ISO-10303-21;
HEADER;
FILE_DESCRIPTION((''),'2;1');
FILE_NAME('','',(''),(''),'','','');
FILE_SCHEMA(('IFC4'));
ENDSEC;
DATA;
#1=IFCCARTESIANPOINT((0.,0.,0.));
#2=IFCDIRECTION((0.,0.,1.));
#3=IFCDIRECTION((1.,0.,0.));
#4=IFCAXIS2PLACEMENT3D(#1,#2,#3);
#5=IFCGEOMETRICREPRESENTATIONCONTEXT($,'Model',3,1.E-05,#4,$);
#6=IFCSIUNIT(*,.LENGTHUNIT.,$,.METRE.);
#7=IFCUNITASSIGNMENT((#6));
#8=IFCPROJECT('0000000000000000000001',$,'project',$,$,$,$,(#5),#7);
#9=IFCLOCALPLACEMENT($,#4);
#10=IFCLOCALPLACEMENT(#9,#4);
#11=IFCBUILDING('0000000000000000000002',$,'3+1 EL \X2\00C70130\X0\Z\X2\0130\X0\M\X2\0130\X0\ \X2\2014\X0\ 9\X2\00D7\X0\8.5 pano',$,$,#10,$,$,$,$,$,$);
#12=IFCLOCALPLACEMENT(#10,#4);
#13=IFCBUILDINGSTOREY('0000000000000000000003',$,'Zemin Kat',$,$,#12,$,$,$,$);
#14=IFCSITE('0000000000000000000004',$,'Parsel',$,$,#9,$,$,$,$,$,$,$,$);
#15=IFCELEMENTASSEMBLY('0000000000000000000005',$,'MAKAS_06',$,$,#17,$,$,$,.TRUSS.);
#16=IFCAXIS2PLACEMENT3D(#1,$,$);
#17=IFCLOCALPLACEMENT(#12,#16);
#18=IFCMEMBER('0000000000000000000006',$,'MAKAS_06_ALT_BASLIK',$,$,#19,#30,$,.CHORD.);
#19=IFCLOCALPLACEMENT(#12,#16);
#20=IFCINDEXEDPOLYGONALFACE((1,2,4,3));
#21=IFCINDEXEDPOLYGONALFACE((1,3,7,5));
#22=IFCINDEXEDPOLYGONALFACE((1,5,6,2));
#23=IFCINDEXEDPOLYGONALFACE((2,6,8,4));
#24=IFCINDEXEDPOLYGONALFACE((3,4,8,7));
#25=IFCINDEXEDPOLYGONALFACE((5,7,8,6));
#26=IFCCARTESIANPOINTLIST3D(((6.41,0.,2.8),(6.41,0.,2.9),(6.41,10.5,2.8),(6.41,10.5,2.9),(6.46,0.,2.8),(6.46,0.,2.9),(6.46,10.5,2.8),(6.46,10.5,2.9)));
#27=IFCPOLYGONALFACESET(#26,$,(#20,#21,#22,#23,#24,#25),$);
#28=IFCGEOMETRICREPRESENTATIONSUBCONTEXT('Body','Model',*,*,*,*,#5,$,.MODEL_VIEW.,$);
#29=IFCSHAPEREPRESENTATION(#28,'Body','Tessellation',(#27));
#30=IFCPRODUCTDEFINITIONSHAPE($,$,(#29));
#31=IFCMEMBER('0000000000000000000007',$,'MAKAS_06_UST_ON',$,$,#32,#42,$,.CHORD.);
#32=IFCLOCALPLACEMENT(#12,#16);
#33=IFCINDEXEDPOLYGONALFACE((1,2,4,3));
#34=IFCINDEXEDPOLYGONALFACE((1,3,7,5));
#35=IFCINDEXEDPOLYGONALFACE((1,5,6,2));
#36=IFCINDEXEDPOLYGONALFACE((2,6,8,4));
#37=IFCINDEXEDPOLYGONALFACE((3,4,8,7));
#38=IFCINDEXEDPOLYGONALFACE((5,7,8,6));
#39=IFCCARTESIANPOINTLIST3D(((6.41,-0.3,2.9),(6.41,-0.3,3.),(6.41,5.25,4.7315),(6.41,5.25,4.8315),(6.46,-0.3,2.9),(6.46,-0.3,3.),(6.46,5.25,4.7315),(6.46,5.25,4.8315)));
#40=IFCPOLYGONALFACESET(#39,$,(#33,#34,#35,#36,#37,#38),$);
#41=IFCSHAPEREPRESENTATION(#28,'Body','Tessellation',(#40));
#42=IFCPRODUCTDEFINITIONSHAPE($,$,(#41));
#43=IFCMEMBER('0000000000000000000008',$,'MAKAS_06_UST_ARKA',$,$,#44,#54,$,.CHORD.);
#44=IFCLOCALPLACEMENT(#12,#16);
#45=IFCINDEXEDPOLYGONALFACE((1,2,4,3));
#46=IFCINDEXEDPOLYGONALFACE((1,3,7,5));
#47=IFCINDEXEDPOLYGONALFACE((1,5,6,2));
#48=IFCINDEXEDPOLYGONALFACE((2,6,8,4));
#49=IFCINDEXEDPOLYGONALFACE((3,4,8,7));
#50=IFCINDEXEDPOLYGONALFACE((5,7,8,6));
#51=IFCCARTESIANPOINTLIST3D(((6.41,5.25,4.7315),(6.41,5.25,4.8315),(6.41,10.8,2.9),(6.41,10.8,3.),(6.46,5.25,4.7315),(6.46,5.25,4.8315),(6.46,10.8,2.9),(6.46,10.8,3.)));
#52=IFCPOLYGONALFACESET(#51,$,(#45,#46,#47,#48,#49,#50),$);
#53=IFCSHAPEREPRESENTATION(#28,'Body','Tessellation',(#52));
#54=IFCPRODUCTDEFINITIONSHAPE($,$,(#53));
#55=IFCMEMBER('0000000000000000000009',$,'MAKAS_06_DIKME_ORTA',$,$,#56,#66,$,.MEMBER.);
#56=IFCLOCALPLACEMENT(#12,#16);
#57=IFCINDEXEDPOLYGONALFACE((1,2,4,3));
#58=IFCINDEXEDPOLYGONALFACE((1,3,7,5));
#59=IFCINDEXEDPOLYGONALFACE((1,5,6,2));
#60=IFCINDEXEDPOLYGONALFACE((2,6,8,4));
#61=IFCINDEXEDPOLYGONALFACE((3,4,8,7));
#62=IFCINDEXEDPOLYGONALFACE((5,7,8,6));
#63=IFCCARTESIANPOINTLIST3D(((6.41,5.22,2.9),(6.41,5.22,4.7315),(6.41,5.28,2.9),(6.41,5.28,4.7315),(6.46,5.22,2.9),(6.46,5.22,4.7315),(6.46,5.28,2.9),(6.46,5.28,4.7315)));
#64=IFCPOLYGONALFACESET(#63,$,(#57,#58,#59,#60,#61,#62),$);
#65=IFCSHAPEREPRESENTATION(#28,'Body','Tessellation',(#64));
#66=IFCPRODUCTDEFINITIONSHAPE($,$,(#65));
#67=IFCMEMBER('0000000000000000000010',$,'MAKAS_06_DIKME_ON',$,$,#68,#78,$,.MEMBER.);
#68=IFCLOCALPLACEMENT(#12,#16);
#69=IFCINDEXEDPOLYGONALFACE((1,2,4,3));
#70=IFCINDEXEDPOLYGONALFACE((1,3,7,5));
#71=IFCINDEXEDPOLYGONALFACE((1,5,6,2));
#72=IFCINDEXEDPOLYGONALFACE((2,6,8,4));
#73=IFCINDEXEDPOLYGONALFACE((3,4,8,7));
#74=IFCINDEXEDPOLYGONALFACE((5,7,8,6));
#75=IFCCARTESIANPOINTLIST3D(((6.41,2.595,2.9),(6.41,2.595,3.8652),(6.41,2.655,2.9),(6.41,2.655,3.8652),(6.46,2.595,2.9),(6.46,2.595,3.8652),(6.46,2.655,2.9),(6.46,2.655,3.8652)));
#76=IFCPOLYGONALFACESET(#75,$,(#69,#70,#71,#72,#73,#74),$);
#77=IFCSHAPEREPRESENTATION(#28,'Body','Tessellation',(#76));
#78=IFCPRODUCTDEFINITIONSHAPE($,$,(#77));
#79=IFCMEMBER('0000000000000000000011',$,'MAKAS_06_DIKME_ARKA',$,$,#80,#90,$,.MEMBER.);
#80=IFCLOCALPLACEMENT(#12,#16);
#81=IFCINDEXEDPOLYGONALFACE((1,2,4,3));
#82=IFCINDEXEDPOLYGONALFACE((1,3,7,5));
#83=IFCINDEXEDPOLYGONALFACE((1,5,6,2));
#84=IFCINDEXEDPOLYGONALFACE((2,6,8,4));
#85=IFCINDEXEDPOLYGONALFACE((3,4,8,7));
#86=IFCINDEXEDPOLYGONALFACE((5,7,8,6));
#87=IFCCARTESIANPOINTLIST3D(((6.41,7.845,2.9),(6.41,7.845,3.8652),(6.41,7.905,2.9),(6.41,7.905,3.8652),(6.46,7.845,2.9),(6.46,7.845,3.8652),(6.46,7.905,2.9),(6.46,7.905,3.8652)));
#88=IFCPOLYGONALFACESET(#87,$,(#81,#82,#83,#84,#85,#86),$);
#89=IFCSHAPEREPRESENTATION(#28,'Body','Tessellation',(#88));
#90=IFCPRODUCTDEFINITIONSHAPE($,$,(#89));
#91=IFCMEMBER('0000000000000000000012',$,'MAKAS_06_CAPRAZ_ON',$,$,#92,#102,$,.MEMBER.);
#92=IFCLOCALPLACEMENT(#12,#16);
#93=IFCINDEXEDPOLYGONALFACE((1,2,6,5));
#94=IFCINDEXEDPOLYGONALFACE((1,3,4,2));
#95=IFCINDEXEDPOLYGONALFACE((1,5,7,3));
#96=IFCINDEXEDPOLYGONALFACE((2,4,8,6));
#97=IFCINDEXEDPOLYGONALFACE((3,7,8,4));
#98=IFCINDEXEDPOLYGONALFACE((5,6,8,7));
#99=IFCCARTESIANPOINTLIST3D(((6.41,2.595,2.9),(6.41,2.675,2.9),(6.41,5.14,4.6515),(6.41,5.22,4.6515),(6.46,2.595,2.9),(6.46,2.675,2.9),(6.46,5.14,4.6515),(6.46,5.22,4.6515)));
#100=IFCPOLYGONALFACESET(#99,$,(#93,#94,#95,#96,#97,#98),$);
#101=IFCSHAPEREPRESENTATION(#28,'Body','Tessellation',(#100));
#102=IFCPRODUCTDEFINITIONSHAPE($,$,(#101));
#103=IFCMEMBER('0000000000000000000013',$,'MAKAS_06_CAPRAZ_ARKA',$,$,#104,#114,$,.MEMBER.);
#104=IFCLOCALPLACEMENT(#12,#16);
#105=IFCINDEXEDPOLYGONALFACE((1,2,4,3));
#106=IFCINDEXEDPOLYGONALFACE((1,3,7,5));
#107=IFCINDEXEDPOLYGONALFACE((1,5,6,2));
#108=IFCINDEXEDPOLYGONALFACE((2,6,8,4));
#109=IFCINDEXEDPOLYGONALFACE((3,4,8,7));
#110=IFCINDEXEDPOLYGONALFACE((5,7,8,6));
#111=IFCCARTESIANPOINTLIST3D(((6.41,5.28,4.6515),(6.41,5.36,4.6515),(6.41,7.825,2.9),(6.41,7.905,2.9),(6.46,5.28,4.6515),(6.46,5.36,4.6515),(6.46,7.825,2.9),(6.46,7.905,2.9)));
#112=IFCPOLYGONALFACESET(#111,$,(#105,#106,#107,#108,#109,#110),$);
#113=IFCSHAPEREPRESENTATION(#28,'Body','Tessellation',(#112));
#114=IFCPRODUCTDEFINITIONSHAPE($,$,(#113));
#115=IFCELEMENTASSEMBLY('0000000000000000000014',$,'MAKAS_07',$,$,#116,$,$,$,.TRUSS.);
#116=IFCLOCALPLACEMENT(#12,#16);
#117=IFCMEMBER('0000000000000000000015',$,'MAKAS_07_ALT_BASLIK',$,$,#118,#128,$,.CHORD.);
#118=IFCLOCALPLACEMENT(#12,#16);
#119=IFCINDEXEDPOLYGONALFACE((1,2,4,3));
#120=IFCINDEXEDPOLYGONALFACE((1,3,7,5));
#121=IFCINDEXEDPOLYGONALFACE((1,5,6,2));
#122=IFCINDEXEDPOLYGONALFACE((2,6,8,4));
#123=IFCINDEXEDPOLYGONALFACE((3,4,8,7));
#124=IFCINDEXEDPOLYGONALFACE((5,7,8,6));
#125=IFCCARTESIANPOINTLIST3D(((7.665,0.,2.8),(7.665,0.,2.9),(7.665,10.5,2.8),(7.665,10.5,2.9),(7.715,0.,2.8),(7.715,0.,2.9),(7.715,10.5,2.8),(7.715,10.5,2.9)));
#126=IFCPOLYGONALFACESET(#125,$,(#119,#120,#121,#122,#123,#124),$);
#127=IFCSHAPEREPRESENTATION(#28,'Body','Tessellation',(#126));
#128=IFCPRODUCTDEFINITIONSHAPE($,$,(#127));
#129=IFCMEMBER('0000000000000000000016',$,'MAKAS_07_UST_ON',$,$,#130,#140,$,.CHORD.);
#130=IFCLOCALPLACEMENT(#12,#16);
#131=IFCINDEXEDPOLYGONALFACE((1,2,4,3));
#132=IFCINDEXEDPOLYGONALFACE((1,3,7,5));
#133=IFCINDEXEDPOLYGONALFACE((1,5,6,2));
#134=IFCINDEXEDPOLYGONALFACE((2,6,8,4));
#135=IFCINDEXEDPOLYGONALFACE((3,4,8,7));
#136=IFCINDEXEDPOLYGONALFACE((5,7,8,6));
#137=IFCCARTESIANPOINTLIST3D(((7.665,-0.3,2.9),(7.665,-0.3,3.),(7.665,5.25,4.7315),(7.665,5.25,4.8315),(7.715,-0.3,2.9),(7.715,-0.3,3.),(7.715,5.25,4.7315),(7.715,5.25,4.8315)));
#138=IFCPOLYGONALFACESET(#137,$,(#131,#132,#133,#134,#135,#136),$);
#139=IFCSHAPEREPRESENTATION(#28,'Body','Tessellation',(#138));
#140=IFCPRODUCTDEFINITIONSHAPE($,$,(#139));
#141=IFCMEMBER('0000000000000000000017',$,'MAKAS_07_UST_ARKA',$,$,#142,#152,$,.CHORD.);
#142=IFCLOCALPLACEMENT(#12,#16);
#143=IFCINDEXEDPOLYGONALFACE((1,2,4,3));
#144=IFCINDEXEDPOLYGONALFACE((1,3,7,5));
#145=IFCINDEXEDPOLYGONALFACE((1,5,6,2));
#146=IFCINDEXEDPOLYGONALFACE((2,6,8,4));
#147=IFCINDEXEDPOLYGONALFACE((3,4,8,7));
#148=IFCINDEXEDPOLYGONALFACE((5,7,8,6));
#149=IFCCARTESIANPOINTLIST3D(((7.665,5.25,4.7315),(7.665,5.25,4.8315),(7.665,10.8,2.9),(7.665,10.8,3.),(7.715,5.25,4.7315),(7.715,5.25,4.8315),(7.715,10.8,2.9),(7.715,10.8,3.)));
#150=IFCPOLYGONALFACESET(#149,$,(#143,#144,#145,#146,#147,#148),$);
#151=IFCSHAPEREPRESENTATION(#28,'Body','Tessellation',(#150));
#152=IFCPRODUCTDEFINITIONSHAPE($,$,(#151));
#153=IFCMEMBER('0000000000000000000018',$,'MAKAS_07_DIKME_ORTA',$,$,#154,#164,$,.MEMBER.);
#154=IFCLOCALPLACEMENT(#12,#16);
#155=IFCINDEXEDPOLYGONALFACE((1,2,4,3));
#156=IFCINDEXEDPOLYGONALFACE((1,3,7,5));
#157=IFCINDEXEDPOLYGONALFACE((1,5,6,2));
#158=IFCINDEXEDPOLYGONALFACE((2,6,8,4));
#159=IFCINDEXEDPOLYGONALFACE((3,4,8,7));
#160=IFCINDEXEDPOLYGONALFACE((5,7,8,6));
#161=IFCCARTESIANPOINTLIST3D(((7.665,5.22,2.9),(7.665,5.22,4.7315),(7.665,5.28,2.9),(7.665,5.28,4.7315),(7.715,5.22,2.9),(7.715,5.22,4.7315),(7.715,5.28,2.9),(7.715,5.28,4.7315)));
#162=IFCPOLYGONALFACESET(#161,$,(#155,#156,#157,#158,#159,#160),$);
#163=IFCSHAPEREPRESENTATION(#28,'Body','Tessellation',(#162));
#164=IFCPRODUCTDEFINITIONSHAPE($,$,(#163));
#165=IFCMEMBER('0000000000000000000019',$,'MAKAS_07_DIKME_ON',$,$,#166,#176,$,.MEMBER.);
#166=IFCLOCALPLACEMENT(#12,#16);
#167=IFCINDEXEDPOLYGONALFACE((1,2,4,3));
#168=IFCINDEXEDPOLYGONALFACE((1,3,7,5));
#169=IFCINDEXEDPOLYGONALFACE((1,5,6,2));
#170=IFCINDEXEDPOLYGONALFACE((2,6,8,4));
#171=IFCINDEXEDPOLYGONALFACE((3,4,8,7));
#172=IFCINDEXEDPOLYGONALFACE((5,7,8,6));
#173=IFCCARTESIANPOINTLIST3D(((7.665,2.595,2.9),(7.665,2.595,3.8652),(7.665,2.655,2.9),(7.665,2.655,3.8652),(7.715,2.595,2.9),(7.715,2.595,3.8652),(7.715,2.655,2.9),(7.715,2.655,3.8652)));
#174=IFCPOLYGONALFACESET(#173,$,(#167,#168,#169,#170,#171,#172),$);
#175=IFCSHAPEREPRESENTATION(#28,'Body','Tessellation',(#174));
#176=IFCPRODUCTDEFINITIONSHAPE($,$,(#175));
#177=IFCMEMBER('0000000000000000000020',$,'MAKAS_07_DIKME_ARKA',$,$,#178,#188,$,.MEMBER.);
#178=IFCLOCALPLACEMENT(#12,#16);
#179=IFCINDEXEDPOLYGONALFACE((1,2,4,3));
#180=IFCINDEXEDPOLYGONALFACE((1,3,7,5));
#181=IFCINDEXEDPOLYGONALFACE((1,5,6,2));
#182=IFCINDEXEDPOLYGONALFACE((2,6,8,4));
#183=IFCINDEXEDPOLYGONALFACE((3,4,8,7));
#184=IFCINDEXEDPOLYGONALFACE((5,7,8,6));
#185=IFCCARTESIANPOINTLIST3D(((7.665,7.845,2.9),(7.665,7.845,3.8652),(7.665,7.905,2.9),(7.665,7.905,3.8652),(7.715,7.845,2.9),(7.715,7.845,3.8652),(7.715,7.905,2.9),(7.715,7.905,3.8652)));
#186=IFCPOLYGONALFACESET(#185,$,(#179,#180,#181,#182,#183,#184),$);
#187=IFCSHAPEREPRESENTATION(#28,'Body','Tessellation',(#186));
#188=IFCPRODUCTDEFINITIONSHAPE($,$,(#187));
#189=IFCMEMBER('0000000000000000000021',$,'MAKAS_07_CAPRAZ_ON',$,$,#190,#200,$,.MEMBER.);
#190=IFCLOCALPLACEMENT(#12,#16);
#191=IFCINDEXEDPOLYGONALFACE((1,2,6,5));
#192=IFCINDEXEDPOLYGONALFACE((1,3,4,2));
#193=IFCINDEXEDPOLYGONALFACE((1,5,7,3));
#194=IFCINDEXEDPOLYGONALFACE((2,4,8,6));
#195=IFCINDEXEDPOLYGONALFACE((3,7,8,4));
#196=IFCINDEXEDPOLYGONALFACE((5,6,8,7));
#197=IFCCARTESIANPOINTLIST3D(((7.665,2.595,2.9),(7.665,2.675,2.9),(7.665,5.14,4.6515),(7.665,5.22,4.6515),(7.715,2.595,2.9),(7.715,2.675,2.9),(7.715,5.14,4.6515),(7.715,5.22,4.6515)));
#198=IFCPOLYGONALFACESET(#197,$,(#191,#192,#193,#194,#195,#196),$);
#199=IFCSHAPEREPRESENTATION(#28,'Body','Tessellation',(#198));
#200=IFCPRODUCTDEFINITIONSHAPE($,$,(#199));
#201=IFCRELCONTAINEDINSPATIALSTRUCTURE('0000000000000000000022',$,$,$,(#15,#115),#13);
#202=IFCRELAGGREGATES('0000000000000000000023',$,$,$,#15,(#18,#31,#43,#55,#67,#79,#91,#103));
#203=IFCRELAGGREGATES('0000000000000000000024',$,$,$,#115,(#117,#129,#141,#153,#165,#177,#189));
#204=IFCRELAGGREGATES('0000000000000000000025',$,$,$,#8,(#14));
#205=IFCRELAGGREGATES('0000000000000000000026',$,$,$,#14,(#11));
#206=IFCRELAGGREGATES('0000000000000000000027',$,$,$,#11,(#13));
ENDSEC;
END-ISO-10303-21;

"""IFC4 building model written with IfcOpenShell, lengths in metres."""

from ifc_helpers import new_model, si_unit, frame, origin_with_axes, place, context, subcontext, project, spatial, line, indexed_curve, outline, extrude, element, aggregate, save


model = new_model("IFC4")

# Units and contexts
model_context = context("Model", 3, precision=1e-05, world=origin_with_axes())
body_context = subcontext(model_context, "Body", "Model", "MODEL_VIEW")
ifc_project = project(units=[si_unit("LENGTHUNIT", "METRE")], contexts=[model_context])

# Site, building, storey
site_placement = place(None, origin_with_axes())
site = spatial("IfcSite", under=ifc_project, at=site_placement, Name="Parsel")
building_placement = place(site_placement, origin_with_axes())
building = spatial("IfcBuilding", under=site, at=building_placement, Name="3+1 EL ÇİZİMİ — 9×8.5 pano")
storey_placement = place(building_placement, origin_with_axes())
storey = spatial("IfcBuildingStorey", under=building, at=storey_placement, Name="Zemin Kat")

# Element assemblies, members
assembly_1_placement = place(storey_placement, origin_with_axes())
assembly_1 = element("IfcElementAssembly", 1, at=assembly_1_placement, inside=storey, Name="MAKAS_06", PredefinedType="TRUSS")
member_1_placement = place(assembly_1_placement, origin_with_axes())
member_1 = element("IfcMember", 2, at=member_1_placement, Name="MAKAS_06_ALT_BASLIK", PredefinedType="CHORD", context=body_context, shape_type="SweptSolid", body=[
    extrude(outline(indexed_curve([(0.0, 2.8), (10.5, 2.8), (10.5, 2.9), (0.0, 2.9)], segments=[line(1, 2, 3, 4, 1)])), frame((6.41, 0.0, 0.0), z_axis=(1.0, 0.0, 0.0), x_axis=(0.0, 1.0, 0.0)), (0.0, 0.0, 1.0), 0.05),
])
member_2_placement = place(assembly_1_placement, origin_with_axes())
member_2 = element("IfcMember", 3, at=member_2_placement, Name="MAKAS_06_UST_ON", PredefinedType="CHORD", context=body_context, shape_type="SweptSolid", body=[
    extrude(outline(indexed_curve([(-0.3, 2.9), (5.25, 4.7315), (5.25, 4.8315), (-0.3, 3.0)], segments=[line(1, 2, 3, 4, 1)])), frame((6.41, 0.0, 0.0), z_axis=(1.0, 0.0, 0.0), x_axis=(0.0, 1.0, 0.0)), (0.0, 0.0, 1.0), 0.05),
])
member_3_placement = place(assembly_1_placement, origin_with_axes())
member_3 = element("IfcMember", 4, at=member_3_placement, Name="MAKAS_06_UST_ARKA", PredefinedType="CHORD", context=body_context, shape_type="SweptSolid", body=[
    extrude(outline(indexed_curve([(5.25, 4.7315), (10.8, 2.9), (10.8, 3.0), (5.25, 4.8315)], segments=[line(1, 2, 3, 4, 1)])), frame((6.41, 0.0, 0.0), z_axis=(1.0, 0.0, 0.0), x_axis=(0.0, 1.0, 0.0)), (0.0, 0.0, 1.0), 0.05),
])
member_4_placement = place(assembly_1_placement, origin_with_axes())
member_4 = element("IfcMember", 5, at=member_4_placement, Name="MAKAS_06_DIKME_ORTA", PredefinedType="MEMBER", context=body_context, shape_type="SweptSolid", body=[
    extrude(outline(indexed_curve([(5.22, 2.9), (5.28, 2.9), (5.28, 4.7315), (5.22, 4.7315)], segments=[line(1, 2, 3, 4, 1)])), frame((6.41, 0.0, 0.0), z_axis=(1.0, 0.0, 0.0), x_axis=(0.0, 1.0, 0.0)), (0.0, 0.0, 1.0), 0.05),
])
member_5_placement = place(assembly_1_placement, origin_with_axes())
member_5 = element("IfcMember", 6, at=member_5_placement, Name="MAKAS_06_DIKME_ON", PredefinedType="MEMBER", context=body_context, shape_type="SweptSolid", body=[
    extrude(outline(indexed_curve([(2.595, 2.9), (2.655, 2.9), (2.655, 3.8653), (2.595, 3.8653)], segments=[line(1, 2, 3, 4, 1)])), frame((6.41, 0.0, 0.0), z_axis=(1.0, 0.0, 0.0), x_axis=(0.0, 1.0, 0.0)), (0.0, 0.0, 1.0), 0.05),
])
member_6_placement = place(assembly_1_placement, origin_with_axes())
member_6 = element("IfcMember", 7, at=member_6_placement, Name="MAKAS_06_DIKME_ARKA", PredefinedType="MEMBER", context=body_context, shape_type="SweptSolid", body=[
    extrude(outline(indexed_curve([(7.845, 2.9), (7.905, 2.9), (7.905, 3.8653), (7.845, 3.8653)], segments=[line(1, 2, 3, 4, 1)])), frame((6.41, 0.0, 0.0), z_axis=(1.0, 0.0, 0.0), x_axis=(0.0, 1.0, 0.0)), (0.0, 0.0, 1.0), 0.05),
])
member_7_placement = place(assembly_1_placement, origin_with_axes())
member_7 = element("IfcMember", 8, at=member_7_placement, Name="MAKAS_06_CAPRAZ_ON", PredefinedType="MEMBER", context=body_context, shape_type="SweptSolid", body=[
    extrude(outline(indexed_curve([(2.595, 2.9), (2.675, 2.9), (5.22, 4.6515), (5.14, 4.6515)], segments=[line(1, 2, 3, 4, 1)])), frame((6.41, 0.0, 0.0), z_axis=(1.0, 0.0, 0.0), x_axis=(0.0, 1.0, 0.0)), (0.0, 0.0, 1.0), 0.05),
])
member_8_placement = place(assembly_1_placement, origin_with_axes())
member_8 = element("IfcMember", 9, at=member_8_placement, Name="MAKAS_06_CAPRAZ_ARKA", PredefinedType="MEMBER", context=body_context, shape_type="SweptSolid", body=[
    extrude(outline(indexed_curve([(7.825, 2.9), (7.905, 2.9), (5.36, 4.6515), (5.28, 4.6515)], segments=[line(1, 2, 3, 4, 1)])), frame((6.41, 0.0, 0.0), z_axis=(1.0, 0.0, 0.0), x_axis=(0.0, 1.0, 0.0)), (0.0, 0.0, 1.0), 0.05),
])
aggregate(assembly_1, [member_1, member_2, member_3, member_4, member_5, member_6, member_7, member_8])
assembly_2_placement = place(storey_placement, origin_with_axes())
assembly_2 = element("IfcElementAssembly", 10, at=assembly_2_placement, inside=storey, Name="MAKAS_07", PredefinedType="TRUSS")
member_9_placement = place(assembly_2_placement, origin_with_axes())
member_9 = element("IfcMember", 11, at=member_9_placement, Name="MAKAS_07_ALT_BASLIK", PredefinedType="CHORD", context=body_context, shape_type="SweptSolid", body=[
    extrude(outline(indexed_curve([(0.0, 2.8), (10.5, 2.8), (10.5, 2.9), (0.0, 2.9)], segments=[line(1, 2, 3, 4, 1)])), frame((7.665, 0.0, 0.0), z_axis=(1.0, 0.0, 0.0), x_axis=(0.0, 1.0, 0.0)), (0.0, 0.0, 1.0), 0.05),
])
member_10_placement = place(assembly_2_placement, origin_with_axes())
member_10 = element("IfcMember", 12, at=member_10_placement, Name="MAKAS_07_UST_ON", PredefinedType="CHORD", context=body_context, shape_type="SweptSolid", body=[
    extrude(outline(indexed_curve([(-0.3, 2.9), (5.25, 4.7315), (5.25, 4.8315), (-0.3, 3.0)], segments=[line(1, 2, 3, 4, 1)])), frame((7.665, 0.0, 0.0), z_axis=(1.0, 0.0, 0.0), x_axis=(0.0, 1.0, 0.0)), (0.0, 0.0, 1.0), 0.05),
])
member_11_placement = place(assembly_2_placement, origin_with_axes())
member_11 = element("IfcMember", 13, at=member_11_placement, Name="MAKAS_07_UST_ARKA", PredefinedType="CHORD", context=body_context, shape_type="SweptSolid", body=[
    extrude(outline(indexed_curve([(5.25, 4.7315), (10.8, 2.9), (10.8, 3.0), (5.25, 4.8315)], segments=[line(1, 2, 3, 4, 1)])), frame((7.665, 0.0, 0.0), z_axis=(1.0, 0.0, 0.0), x_axis=(0.0, 1.0, 0.0)), (0.0, 0.0, 1.0), 0.05),
])
member_12_placement = place(assembly_2_placement, origin_with_axes())
member_12 = element("IfcMember", 14, at=member_12_placement, Name="MAKAS_07_DIKME_ORTA", PredefinedType="MEMBER", context=body_context, shape_type="SweptSolid", body=[
    extrude(outline(indexed_curve([(5.22, 2.9), (5.28, 2.9), (5.28, 4.7315), (5.22, 4.7315)], segments=[line(1, 2, 3, 4, 1)])), frame((7.665, 0.0, 0.0), z_axis=(1.0, 0.0, 0.0), x_axis=(0.0, 1.0, 0.0)), (0.0, 0.0, 1.0), 0.05),
])
member_13_placement = place(assembly_2_placement, origin_with_axes())
member_13 = element("IfcMember", 15, at=member_13_placement, Name="MAKAS_07_DIKME_ON", PredefinedType="MEMBER", context=body_context, shape_type="SweptSolid", body=[
    extrude(outline(indexed_curve([(2.595, 2.9), (2.655, 2.9), (2.655, 3.8653), (2.595, 3.8653)], segments=[line(1, 2, 3, 4, 1)])), frame((7.665, 0.0, 0.0), z_axis=(1.0, 0.0, 0.0), x_axis=(0.0, 1.0, 0.0)), (0.0, 0.0, 1.0), 0.05),
])
member_14_placement = place(assembly_2_placement, origin_with_axes())
member_14 = element("IfcMember", 16, at=member_14_placement, Name="MAKAS_07_DIKME_ARKA", PredefinedType="MEMBER", context=body_context, shape_type="SweptSolid", body=[
    extrude(outline(indexed_curve([(7.845, 2.9), (7.905, 2.9), (7.905, 3.8653), (7.845, 3.8653)], segments=[line(1, 2, 3, 4, 1)])), frame((7.665, 0.0, 0.0), z_axis=(1.0, 0.0, 0.0), x_axis=(0.0, 1.0, 0.0)), (0.0, 0.0, 1.0), 0.05),
])
member_15_placement = place(assembly_2_placement, origin_with_axes())
member_15 = element("IfcMember", 17, at=member_15_placement, Name="MAKAS_07_CAPRAZ_ON", PredefinedType="MEMBER", context=body_context, shape_type="SweptSolid", body=[
    extrude(outline(indexed_curve([(2.595, 2.9), (2.675, 2.9), (5.22, 4.6515), (5.14, 4.6515)], segments=[line(1, 2, 3, 4, 1)])), frame((7.665, 0.0, 0.0), z_axis=(1.0, 0.0, 0.0), x_axis=(0.0, 1.0, 0.0)), (0.0, 0.0, 1.0), 0.05),
])
aggregate(assembly_2, [member_9, member_10, member_11, member_12, member_13, member_14, member_15])

save(model, "model.ifc")
